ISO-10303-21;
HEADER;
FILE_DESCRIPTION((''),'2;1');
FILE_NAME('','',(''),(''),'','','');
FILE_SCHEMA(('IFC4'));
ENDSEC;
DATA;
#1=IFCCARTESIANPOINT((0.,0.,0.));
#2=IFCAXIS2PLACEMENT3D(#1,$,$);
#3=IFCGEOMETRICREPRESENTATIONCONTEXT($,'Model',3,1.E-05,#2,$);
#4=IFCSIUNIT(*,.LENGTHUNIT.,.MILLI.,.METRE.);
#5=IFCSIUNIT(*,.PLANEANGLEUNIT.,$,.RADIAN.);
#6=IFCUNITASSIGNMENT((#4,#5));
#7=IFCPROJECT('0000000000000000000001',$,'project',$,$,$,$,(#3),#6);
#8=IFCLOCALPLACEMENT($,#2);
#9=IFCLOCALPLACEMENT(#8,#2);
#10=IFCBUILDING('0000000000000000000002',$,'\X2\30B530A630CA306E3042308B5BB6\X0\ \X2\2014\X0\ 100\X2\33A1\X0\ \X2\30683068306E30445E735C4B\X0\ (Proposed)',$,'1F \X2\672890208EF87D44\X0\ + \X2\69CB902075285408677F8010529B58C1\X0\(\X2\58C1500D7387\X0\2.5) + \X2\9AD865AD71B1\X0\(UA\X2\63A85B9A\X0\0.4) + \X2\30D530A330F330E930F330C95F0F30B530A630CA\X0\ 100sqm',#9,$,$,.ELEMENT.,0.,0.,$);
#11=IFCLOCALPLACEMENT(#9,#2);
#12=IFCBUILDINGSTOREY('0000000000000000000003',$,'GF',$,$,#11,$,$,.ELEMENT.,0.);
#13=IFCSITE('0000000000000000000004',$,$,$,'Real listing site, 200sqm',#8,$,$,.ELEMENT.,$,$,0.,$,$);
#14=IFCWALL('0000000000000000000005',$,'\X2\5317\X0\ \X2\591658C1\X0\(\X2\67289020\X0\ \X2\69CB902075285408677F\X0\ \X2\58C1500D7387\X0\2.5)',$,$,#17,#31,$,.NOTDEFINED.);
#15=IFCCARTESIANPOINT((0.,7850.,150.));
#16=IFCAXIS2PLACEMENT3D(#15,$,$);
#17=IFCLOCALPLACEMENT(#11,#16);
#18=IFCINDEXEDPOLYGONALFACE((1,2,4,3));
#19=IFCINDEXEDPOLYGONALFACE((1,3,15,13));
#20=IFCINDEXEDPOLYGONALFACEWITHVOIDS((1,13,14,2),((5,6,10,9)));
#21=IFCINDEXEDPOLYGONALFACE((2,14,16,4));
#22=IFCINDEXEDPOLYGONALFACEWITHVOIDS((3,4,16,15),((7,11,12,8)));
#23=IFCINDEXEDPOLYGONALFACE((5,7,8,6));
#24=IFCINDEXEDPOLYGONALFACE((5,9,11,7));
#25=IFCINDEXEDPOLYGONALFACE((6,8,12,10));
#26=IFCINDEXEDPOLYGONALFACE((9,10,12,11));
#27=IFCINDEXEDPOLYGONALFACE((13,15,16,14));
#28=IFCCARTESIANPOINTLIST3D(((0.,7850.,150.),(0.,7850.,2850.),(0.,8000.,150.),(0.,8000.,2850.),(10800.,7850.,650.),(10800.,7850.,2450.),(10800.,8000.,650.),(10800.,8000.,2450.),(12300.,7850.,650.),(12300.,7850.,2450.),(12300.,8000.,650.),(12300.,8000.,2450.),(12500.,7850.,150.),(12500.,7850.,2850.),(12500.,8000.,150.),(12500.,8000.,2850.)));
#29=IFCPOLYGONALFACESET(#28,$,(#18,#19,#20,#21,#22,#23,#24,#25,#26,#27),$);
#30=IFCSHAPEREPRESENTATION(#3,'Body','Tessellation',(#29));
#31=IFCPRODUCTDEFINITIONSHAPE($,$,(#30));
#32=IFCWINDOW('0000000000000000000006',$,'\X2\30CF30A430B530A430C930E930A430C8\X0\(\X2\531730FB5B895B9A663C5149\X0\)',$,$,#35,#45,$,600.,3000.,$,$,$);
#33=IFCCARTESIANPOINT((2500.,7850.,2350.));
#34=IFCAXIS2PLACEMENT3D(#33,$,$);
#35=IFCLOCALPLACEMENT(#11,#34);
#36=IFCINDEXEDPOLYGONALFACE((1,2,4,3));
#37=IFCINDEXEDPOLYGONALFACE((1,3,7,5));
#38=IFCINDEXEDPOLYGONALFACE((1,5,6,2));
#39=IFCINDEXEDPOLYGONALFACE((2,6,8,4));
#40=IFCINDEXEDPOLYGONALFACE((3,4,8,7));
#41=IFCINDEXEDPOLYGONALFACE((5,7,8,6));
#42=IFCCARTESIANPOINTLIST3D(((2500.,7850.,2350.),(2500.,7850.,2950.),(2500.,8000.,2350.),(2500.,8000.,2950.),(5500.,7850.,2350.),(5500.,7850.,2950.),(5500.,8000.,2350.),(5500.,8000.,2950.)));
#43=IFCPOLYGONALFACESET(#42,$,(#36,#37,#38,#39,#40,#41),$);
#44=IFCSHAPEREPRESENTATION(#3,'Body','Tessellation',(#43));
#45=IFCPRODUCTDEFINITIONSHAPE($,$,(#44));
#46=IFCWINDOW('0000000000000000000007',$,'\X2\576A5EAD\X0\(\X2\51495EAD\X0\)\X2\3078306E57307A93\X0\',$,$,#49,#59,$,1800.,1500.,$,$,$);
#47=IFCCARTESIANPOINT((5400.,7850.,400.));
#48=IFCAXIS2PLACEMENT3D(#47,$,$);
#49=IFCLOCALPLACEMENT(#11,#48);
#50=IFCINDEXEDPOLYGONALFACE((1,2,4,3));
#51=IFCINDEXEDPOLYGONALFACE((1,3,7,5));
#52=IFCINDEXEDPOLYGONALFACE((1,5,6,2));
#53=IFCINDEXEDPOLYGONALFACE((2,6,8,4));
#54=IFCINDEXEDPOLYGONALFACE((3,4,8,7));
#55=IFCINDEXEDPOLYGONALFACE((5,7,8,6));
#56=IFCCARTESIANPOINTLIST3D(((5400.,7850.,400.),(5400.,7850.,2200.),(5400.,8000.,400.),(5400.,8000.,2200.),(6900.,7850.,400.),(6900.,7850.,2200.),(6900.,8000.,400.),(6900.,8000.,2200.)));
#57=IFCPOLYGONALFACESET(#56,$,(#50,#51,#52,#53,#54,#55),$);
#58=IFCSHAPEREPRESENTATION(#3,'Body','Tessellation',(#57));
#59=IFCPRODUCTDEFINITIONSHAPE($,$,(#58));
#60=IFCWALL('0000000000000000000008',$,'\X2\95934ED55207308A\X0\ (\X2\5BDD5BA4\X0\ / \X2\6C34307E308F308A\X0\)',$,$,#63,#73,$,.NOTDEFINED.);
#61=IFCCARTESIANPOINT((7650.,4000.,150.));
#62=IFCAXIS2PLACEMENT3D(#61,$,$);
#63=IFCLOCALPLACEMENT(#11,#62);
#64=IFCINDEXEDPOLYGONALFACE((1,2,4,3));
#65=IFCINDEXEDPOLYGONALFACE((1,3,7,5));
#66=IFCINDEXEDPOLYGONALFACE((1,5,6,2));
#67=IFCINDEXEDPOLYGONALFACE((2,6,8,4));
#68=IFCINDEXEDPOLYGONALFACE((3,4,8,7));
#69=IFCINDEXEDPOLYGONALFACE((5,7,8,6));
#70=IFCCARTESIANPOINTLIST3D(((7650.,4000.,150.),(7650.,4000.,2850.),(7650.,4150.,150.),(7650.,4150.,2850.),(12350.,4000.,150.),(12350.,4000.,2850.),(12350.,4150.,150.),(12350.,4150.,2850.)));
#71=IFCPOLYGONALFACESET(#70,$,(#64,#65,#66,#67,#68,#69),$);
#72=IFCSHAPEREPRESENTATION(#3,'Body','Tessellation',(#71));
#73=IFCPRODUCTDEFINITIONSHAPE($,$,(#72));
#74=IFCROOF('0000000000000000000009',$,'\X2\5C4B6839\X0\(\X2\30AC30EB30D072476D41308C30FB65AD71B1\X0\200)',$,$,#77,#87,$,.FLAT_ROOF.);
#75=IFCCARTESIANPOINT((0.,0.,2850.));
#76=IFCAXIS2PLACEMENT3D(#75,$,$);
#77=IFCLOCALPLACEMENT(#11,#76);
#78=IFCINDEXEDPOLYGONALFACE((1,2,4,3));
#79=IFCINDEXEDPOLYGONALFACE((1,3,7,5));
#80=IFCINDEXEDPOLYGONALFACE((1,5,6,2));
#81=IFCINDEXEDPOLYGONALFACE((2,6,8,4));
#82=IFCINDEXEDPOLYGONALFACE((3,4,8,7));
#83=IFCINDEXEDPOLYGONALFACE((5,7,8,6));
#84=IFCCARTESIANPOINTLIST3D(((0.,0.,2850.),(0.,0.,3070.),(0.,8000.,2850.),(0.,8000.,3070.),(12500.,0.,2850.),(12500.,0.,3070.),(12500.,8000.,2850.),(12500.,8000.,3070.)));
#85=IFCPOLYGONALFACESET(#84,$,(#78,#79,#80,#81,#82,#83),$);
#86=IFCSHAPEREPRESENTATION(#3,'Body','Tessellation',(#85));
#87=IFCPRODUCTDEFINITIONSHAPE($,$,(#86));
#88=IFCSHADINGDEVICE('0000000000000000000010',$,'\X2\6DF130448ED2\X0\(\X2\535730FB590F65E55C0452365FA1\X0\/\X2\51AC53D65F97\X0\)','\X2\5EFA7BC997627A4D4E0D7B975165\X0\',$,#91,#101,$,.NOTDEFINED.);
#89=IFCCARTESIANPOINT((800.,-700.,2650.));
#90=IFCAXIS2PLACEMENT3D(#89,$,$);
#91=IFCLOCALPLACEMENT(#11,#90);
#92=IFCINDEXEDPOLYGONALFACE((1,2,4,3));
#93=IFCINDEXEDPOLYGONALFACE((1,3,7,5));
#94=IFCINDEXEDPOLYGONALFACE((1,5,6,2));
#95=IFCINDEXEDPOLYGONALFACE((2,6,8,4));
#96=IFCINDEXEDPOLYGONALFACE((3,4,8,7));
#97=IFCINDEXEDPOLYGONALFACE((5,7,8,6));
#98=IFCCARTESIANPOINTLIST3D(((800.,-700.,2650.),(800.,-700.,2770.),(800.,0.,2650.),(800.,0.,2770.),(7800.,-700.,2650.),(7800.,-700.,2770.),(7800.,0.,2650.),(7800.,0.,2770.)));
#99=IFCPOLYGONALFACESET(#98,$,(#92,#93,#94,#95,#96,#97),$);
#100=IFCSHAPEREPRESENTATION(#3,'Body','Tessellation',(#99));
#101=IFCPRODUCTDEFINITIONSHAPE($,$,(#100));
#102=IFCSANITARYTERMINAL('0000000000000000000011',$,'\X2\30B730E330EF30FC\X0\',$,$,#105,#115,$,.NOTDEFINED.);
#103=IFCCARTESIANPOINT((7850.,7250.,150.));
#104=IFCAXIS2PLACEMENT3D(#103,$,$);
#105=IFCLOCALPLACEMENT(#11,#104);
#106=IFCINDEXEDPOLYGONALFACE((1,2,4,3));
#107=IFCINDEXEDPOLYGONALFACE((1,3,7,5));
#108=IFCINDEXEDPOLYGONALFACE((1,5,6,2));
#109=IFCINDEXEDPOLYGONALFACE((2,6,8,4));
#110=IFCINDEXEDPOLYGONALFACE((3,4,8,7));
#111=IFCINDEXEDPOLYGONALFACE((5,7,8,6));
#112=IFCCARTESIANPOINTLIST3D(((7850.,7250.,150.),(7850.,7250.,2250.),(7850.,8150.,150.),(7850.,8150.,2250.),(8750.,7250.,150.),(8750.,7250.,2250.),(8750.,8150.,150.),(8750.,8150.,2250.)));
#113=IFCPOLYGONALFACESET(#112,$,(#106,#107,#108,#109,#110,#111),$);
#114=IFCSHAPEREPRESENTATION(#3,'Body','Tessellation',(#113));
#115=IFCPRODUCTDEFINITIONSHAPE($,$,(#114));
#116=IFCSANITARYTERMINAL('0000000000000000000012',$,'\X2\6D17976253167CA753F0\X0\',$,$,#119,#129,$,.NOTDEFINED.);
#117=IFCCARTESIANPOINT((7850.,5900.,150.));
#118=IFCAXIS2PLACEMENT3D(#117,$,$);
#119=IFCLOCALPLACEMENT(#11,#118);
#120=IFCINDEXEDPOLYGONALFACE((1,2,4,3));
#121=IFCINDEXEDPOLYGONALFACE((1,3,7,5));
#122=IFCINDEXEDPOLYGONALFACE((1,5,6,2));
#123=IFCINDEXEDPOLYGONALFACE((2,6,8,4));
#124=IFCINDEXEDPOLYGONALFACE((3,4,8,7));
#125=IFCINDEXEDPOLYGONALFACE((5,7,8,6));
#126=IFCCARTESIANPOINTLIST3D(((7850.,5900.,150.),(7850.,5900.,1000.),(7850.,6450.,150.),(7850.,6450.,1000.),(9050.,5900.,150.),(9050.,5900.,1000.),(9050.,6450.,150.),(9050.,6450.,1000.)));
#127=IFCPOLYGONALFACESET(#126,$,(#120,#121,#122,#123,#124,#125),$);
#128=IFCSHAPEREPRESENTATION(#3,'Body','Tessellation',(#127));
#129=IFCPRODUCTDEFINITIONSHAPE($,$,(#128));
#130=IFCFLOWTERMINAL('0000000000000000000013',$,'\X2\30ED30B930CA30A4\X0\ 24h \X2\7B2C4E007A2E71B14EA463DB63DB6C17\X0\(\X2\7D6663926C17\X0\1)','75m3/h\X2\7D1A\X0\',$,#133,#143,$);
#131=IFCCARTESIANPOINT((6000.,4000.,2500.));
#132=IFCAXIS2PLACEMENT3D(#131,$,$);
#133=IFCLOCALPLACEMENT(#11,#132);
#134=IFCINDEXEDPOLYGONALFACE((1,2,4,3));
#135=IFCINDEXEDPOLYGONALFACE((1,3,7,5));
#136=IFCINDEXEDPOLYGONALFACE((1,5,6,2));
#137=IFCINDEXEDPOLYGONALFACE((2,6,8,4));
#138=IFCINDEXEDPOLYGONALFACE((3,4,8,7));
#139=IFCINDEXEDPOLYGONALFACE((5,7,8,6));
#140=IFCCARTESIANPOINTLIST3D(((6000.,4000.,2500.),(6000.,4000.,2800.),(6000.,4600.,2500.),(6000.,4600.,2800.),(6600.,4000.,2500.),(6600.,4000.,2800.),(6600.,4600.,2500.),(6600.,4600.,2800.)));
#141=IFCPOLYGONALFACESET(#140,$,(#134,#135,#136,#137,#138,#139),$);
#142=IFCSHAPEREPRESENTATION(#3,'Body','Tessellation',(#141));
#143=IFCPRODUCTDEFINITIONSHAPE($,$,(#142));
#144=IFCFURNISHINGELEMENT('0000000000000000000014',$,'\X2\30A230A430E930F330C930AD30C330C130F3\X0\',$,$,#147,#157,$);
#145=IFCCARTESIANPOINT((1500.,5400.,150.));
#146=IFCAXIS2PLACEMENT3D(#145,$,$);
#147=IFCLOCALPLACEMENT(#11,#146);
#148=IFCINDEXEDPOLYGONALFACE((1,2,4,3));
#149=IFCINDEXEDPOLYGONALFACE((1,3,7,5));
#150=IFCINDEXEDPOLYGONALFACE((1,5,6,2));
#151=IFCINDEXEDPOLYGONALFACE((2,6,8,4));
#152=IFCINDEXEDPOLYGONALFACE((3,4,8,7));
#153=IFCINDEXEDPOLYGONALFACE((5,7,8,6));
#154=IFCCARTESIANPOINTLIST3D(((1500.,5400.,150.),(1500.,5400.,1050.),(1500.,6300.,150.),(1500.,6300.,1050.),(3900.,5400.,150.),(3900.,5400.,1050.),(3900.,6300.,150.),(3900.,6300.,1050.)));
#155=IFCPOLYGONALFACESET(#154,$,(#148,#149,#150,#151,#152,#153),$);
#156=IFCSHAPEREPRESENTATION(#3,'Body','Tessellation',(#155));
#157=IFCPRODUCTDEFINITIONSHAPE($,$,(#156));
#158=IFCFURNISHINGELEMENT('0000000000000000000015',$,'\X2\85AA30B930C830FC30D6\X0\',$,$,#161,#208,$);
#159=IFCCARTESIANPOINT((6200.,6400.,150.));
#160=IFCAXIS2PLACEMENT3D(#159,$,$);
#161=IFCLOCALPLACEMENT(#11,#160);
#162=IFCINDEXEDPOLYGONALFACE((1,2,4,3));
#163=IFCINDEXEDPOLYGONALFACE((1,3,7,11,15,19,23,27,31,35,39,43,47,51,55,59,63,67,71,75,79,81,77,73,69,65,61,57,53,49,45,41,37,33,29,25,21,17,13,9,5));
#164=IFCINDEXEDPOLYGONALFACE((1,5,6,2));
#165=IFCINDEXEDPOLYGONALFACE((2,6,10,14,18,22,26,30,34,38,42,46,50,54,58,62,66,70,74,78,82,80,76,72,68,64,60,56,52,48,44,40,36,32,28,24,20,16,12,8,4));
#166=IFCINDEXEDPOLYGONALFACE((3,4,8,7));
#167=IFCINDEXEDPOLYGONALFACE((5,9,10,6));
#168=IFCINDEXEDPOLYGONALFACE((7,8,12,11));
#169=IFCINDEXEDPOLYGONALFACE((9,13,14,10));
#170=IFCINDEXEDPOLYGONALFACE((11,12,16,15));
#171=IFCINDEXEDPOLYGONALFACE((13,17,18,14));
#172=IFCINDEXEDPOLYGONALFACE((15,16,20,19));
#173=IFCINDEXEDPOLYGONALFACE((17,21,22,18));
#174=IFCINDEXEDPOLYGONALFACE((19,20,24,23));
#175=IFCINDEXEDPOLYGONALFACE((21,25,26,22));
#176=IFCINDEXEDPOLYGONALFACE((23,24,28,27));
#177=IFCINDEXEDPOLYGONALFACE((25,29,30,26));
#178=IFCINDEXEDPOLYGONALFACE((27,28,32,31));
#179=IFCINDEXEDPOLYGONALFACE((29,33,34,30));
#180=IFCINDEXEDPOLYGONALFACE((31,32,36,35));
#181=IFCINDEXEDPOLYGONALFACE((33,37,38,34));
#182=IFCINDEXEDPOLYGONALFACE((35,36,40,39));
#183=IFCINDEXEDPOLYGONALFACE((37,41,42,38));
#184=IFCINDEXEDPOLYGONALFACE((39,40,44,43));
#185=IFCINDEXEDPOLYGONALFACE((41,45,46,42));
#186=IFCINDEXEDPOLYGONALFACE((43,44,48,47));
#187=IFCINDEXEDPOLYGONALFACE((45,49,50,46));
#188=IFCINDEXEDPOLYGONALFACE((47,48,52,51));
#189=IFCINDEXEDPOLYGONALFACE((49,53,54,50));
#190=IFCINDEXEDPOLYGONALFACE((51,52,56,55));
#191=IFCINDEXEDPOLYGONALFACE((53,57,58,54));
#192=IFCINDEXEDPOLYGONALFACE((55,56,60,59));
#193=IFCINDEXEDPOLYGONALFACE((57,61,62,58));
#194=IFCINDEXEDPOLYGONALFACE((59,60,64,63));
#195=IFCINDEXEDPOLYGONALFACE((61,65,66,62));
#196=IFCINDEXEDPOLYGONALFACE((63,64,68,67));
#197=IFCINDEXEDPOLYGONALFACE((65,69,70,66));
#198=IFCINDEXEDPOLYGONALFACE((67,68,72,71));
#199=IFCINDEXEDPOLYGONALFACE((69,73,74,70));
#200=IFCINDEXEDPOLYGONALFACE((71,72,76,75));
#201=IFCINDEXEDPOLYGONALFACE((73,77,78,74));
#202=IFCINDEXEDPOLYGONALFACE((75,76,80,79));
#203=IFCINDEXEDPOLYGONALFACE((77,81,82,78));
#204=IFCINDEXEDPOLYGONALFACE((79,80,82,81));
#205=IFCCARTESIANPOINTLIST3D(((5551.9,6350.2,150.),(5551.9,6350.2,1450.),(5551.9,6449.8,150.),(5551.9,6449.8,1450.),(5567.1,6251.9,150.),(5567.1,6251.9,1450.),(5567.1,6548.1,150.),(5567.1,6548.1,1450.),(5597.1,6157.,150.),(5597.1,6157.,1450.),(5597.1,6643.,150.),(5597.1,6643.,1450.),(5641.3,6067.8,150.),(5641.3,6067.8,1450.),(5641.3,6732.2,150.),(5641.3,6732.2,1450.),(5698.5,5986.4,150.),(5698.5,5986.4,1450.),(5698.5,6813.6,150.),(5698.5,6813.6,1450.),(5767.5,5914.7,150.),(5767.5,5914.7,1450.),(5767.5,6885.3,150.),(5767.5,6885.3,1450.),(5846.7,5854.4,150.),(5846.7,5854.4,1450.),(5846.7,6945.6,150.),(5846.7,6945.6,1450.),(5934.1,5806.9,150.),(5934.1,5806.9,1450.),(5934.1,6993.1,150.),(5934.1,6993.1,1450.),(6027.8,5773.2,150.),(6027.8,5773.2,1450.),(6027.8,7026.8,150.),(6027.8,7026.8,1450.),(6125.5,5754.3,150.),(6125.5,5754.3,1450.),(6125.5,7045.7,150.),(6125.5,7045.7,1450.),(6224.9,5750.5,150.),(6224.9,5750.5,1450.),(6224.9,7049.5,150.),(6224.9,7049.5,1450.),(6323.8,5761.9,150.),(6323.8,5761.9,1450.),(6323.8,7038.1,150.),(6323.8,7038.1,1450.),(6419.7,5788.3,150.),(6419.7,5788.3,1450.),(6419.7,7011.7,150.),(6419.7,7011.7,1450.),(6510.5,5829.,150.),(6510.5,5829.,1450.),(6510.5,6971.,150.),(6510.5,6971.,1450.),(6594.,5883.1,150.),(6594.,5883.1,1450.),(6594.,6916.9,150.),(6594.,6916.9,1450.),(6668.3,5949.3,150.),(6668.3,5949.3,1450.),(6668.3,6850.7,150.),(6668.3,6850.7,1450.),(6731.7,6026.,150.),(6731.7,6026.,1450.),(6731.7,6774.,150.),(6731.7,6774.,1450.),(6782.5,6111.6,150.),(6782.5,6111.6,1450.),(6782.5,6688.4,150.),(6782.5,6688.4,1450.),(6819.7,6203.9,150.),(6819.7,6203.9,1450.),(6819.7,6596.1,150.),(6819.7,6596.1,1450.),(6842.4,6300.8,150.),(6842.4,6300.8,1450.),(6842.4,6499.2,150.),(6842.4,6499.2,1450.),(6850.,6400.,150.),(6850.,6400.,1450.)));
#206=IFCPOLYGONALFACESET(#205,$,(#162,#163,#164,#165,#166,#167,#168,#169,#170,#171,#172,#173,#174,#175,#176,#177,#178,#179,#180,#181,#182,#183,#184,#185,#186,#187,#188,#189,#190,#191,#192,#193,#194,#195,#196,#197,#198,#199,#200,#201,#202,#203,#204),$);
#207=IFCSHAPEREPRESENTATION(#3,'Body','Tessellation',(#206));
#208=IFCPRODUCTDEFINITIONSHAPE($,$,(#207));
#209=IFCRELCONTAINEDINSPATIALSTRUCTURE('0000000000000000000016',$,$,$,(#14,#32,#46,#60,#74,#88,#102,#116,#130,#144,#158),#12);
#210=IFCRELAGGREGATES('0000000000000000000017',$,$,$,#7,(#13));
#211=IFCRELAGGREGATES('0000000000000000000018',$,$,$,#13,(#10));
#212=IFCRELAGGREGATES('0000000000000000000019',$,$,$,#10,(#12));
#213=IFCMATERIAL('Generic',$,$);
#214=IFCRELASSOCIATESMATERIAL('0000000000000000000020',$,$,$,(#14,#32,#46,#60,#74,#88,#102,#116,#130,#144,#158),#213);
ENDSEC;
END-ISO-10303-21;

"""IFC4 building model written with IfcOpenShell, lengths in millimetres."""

from ifc_helpers import new_model, si_unit, frame, frame_2d, origin, origin_2d, place, context, project, spatial, rectangle, circle, extrude, material, element, fill, save


model = new_model("IFC4")

# Units and contexts
model_context = context("Model", 3, precision=1e-05, world=origin())
ifc_project = project(units=[si_unit("LENGTHUNIT", "METRE", prefix="MILLI"), si_unit("PLANEANGLEUNIT", "RADIAN")], contexts=[model_context])

# Site, building, storey
site_placement = place(None, origin())
site = spatial("IfcSite", under=ifc_project, at=site_placement, ObjectType="Real listing site, 200sqm", CompositionType="ELEMENT", RefElevation=0.0)
building_placement = place(site_placement, origin())
building = spatial("IfcBuilding", under=site, at=building_placement, Name="サウナのある家 — 100㎡ ととのい平屋 (Proposed)", ObjectType="1F 木造軸組 + 構造用合板耐力壁(壁倍率2.5) + 高断熱(UA推定0.4) + フィンランド式サウナ 100sqm", CompositionType="ELEMENT", ElevationOfRefHeight=0.0, ElevationOfTerrain=0.0)
storey_placement = place(building_placement, origin())
storey = spatial("IfcBuildingStorey", under=building, at=storey_placement, Name="GF", CompositionType="ELEMENT", Elevation=0.0)

# Shared definitions
ifc_material = material(Name="Generic")

# Wall, openings, windows
wall_1_placement = place(storey_placement, frame((0.0, 7850.0, 150.0)))
wall_1 = element("IfcWall", 1, at=wall_1_placement, inside=storey, material=ifc_material, Name="北 外壁(木造 構造用合板 壁倍率2.5)", PredefinedType="NOTDEFINED", context=model_context, shape_type="SweptSolid", body=[
    extrude(rectangle(XDim=12500.0, YDim=150.0, at=frame_2d((6250.0, 75.0))), frame((0.0, 7850.0, 150.0)), (0.0, 0.0, 1.0), 2700.0),
])
opening_1_placement = place(storey_placement, frame((2500.0, 7850.0, 2350.0)))
opening_1 = element("IfcOpeningElement", 2, at=opening_1_placement, cuts=wall_1, PredefinedType="NOTDEFINED", context=model_context, shape_type="SweptSolid", body=[
    extrude(rectangle(XDim=3000.0, YDim=150.0, at=frame_2d((1500.0, 75.0))), frame((2500.0, 7850.0, 2350.0)), (0.0, 0.0, 1.0), 600.0),
])
opening_2_placement = place(storey_placement, frame((5400.0, 7850.0, 400.0)))
opening_2 = element("IfcOpeningElement", 3, at=opening_2_placement, cuts=wall_1, PredefinedType="NOTDEFINED", context=model_context, shape_type="SweptSolid", body=[
    extrude(rectangle(XDim=1500.0, YDim=150.0, at=frame_2d((750.0, 75.0))), frame((5400.0, 7850.0, 400.0)), (0.0, 0.0, 1.0), 1800.0),
])
window_1_placement = place(storey_placement, frame((2500.0, 7850.0, 2350.0)))
window_1 = element("IfcWindow", 4, at=window_1_placement, inside=storey, material=ifc_material, Name="ハイサイドライト(北・安定昼光)", OverallHeight=600.0, OverallWidth=3000.0, context=model_context, shape_type="SweptSolid", body=[
    extrude(rectangle(XDim=3000.0, YDim=150.0, at=frame_2d((1500.0, 75.0))), frame((2500.0, 7850.0, 2350.0)), (0.0, 0.0, 1.0), 600.0),
])
fill(opening_1, window_1)
window_2_placement = place(storey_placement, frame((5400.0, 7850.0, 400.0)))
window_2 = element("IfcWindow", 5, at=window_2_placement, inside=storey, material=ifc_material, Name="坪庭(光庭)への地窓", OverallHeight=1800.0, OverallWidth=1500.0, context=model_context, shape_type="SweptSolid", body=[
    extrude(rectangle(XDim=1500.0, YDim=150.0, at=frame_2d((750.0, 75.0))), frame((5400.0, 7850.0, 400.0)), (0.0, 0.0, 1.0), 1800.0),
])
fill(opening_2, window_2)

# Wall
wall_2_placement = place(storey_placement, frame((7650.0, 4000.0, 150.0)))
element("IfcWall", 6, at=wall_2_placement, inside=storey, material=ifc_material, Name="間仕切り (寝室 / 水まわり)", PredefinedType="NOTDEFINED", context=model_context, shape_type="SweptSolid", body=[
    extrude(rectangle(XDim=4700.0, YDim=150.0, at=frame_2d((2350.0, 75.0))), frame((7650.0, 4000.0, 150.0)), (0.0, 0.0, 1.0), 2700.0),
])

# Roof
roof_placement = place(storey_placement, frame((0.0, 0.0, 2850.0)))
element("IfcRoof", 7, at=roof_placement, inside=storey, material=ifc_material, Name="屋根(ガルバ片流れ・断熱200)", PredefinedType="FLAT_ROOF", context=model_context, shape_type="SweptSolid", body=[
    extrude(rectangle(XDim=12500.0, YDim=8000.0, at=frame_2d((6250.0, 4000.0))), frame((0.0, 0.0, 2850.0)), (0.0, 0.0, 1.0), 220.0),
])

# Shading device
shading_device_placement = place(storey_placement, frame((800.0, -700.0, 2650.0)))
element("IfcShadingDevice", 8, at=shading_device_placement, inside=storey, material=ifc_material, Name="深い軒(南・夏日射制御/冬取得)", Description="建築面積不算入", PredefinedType="NOTDEFINED", context=model_context, shape_type="SweptSolid", body=[
    extrude(rectangle(XDim=7000.0, YDim=700.0, at=frame_2d((3500.0, 350.0))), frame((800.0, -700.0, 2650.0)), (0.0, 0.0, 1.0), 120.0),
])

# Sanitary terminals
sanitary_terminal_1_placement = place(storey_placement, frame((7850.0, 7250.0, 150.0)))
element("IfcSanitaryTerminal", 9, at=sanitary_terminal_1_placement, inside=storey, material=ifc_material, Name="シャワー", PredefinedType="NOTDEFINED", context=model_context, shape_type="SweptSolid", body=[
    extrude(rectangle(XDim=900.0, YDim=900.0, at=frame_2d((450.0, 450.0))), frame((7850.0, 7250.0, 150.0)), (0.0, 0.0, 1.0), 2100.0),
])
sanitary_terminal_2_placement = place(storey_placement, frame((7850.0, 5900.0, 150.0)))
element("IfcSanitaryTerminal", 10, at=sanitary_terminal_2_placement, inside=storey, material=ifc_material, Name="洗面化粧台", PredefinedType="NOTDEFINED", context=model_context, shape_type="SweptSolid", body=[
    extrude(rectangle(XDim=1200.0, YDim=550.0, at=frame_2d((600.0, 275.0))), frame((7850.0, 5900.0, 150.0)), (0.0, 0.0, 1.0), 850.0),
])

# Flow terminal
flow_terminal_placement = place(storey_placement, frame((6000.0, 4000.0, 2500.0)))
element("IfcFlowTerminal", 11, at=flow_terminal_placement, inside=storey, material=ifc_material, Name="ロスナイ 24h 第一種熱交換換気(給排気1)", Description="75m3/h級", context=model_context, shape_type="SweptSolid", body=[
    extrude(rectangle(XDim=600.0, YDim=600.0, at=frame_2d((300.0, 300.0))), frame((6000.0, 4000.0, 2500.0)), (0.0, 0.0, 1.0), 300.0),
])

# Furnishing elements
furnishing_1_placement = place(storey_placement, frame((1500.0, 5400.0, 150.0)))
element("IfcFurnishingElement", 12, at=furnishing_1_placement, inside=storey, material=ifc_material, Name="アイランドキッチン", context=model_context, shape_type="SweptSolid", body=[
    extrude(rectangle(XDim=2400.0, YDim=900.0, at=frame_2d((1200.0, 450.0))), frame((1500.0, 5400.0, 150.0)), (0.0, 0.0, 1.0), 900.0),
])
furnishing_2_placement = place(storey_placement, frame((6200.0, 6400.0, 150.0)))
element("IfcFurnishingElement", 13, at=furnishing_2_placement, inside=storey, material=ifc_material, Name="薪ストーブ", context=model_context, shape_type="SweptSolid", body=[
    extrude(circle(Radius=650.0, at=origin_2d()), frame((6200.0, 6400.0, 150.0)), (0.0, 0.0, 1.0), 1300.0),
])

save(model, "model.ifc")
